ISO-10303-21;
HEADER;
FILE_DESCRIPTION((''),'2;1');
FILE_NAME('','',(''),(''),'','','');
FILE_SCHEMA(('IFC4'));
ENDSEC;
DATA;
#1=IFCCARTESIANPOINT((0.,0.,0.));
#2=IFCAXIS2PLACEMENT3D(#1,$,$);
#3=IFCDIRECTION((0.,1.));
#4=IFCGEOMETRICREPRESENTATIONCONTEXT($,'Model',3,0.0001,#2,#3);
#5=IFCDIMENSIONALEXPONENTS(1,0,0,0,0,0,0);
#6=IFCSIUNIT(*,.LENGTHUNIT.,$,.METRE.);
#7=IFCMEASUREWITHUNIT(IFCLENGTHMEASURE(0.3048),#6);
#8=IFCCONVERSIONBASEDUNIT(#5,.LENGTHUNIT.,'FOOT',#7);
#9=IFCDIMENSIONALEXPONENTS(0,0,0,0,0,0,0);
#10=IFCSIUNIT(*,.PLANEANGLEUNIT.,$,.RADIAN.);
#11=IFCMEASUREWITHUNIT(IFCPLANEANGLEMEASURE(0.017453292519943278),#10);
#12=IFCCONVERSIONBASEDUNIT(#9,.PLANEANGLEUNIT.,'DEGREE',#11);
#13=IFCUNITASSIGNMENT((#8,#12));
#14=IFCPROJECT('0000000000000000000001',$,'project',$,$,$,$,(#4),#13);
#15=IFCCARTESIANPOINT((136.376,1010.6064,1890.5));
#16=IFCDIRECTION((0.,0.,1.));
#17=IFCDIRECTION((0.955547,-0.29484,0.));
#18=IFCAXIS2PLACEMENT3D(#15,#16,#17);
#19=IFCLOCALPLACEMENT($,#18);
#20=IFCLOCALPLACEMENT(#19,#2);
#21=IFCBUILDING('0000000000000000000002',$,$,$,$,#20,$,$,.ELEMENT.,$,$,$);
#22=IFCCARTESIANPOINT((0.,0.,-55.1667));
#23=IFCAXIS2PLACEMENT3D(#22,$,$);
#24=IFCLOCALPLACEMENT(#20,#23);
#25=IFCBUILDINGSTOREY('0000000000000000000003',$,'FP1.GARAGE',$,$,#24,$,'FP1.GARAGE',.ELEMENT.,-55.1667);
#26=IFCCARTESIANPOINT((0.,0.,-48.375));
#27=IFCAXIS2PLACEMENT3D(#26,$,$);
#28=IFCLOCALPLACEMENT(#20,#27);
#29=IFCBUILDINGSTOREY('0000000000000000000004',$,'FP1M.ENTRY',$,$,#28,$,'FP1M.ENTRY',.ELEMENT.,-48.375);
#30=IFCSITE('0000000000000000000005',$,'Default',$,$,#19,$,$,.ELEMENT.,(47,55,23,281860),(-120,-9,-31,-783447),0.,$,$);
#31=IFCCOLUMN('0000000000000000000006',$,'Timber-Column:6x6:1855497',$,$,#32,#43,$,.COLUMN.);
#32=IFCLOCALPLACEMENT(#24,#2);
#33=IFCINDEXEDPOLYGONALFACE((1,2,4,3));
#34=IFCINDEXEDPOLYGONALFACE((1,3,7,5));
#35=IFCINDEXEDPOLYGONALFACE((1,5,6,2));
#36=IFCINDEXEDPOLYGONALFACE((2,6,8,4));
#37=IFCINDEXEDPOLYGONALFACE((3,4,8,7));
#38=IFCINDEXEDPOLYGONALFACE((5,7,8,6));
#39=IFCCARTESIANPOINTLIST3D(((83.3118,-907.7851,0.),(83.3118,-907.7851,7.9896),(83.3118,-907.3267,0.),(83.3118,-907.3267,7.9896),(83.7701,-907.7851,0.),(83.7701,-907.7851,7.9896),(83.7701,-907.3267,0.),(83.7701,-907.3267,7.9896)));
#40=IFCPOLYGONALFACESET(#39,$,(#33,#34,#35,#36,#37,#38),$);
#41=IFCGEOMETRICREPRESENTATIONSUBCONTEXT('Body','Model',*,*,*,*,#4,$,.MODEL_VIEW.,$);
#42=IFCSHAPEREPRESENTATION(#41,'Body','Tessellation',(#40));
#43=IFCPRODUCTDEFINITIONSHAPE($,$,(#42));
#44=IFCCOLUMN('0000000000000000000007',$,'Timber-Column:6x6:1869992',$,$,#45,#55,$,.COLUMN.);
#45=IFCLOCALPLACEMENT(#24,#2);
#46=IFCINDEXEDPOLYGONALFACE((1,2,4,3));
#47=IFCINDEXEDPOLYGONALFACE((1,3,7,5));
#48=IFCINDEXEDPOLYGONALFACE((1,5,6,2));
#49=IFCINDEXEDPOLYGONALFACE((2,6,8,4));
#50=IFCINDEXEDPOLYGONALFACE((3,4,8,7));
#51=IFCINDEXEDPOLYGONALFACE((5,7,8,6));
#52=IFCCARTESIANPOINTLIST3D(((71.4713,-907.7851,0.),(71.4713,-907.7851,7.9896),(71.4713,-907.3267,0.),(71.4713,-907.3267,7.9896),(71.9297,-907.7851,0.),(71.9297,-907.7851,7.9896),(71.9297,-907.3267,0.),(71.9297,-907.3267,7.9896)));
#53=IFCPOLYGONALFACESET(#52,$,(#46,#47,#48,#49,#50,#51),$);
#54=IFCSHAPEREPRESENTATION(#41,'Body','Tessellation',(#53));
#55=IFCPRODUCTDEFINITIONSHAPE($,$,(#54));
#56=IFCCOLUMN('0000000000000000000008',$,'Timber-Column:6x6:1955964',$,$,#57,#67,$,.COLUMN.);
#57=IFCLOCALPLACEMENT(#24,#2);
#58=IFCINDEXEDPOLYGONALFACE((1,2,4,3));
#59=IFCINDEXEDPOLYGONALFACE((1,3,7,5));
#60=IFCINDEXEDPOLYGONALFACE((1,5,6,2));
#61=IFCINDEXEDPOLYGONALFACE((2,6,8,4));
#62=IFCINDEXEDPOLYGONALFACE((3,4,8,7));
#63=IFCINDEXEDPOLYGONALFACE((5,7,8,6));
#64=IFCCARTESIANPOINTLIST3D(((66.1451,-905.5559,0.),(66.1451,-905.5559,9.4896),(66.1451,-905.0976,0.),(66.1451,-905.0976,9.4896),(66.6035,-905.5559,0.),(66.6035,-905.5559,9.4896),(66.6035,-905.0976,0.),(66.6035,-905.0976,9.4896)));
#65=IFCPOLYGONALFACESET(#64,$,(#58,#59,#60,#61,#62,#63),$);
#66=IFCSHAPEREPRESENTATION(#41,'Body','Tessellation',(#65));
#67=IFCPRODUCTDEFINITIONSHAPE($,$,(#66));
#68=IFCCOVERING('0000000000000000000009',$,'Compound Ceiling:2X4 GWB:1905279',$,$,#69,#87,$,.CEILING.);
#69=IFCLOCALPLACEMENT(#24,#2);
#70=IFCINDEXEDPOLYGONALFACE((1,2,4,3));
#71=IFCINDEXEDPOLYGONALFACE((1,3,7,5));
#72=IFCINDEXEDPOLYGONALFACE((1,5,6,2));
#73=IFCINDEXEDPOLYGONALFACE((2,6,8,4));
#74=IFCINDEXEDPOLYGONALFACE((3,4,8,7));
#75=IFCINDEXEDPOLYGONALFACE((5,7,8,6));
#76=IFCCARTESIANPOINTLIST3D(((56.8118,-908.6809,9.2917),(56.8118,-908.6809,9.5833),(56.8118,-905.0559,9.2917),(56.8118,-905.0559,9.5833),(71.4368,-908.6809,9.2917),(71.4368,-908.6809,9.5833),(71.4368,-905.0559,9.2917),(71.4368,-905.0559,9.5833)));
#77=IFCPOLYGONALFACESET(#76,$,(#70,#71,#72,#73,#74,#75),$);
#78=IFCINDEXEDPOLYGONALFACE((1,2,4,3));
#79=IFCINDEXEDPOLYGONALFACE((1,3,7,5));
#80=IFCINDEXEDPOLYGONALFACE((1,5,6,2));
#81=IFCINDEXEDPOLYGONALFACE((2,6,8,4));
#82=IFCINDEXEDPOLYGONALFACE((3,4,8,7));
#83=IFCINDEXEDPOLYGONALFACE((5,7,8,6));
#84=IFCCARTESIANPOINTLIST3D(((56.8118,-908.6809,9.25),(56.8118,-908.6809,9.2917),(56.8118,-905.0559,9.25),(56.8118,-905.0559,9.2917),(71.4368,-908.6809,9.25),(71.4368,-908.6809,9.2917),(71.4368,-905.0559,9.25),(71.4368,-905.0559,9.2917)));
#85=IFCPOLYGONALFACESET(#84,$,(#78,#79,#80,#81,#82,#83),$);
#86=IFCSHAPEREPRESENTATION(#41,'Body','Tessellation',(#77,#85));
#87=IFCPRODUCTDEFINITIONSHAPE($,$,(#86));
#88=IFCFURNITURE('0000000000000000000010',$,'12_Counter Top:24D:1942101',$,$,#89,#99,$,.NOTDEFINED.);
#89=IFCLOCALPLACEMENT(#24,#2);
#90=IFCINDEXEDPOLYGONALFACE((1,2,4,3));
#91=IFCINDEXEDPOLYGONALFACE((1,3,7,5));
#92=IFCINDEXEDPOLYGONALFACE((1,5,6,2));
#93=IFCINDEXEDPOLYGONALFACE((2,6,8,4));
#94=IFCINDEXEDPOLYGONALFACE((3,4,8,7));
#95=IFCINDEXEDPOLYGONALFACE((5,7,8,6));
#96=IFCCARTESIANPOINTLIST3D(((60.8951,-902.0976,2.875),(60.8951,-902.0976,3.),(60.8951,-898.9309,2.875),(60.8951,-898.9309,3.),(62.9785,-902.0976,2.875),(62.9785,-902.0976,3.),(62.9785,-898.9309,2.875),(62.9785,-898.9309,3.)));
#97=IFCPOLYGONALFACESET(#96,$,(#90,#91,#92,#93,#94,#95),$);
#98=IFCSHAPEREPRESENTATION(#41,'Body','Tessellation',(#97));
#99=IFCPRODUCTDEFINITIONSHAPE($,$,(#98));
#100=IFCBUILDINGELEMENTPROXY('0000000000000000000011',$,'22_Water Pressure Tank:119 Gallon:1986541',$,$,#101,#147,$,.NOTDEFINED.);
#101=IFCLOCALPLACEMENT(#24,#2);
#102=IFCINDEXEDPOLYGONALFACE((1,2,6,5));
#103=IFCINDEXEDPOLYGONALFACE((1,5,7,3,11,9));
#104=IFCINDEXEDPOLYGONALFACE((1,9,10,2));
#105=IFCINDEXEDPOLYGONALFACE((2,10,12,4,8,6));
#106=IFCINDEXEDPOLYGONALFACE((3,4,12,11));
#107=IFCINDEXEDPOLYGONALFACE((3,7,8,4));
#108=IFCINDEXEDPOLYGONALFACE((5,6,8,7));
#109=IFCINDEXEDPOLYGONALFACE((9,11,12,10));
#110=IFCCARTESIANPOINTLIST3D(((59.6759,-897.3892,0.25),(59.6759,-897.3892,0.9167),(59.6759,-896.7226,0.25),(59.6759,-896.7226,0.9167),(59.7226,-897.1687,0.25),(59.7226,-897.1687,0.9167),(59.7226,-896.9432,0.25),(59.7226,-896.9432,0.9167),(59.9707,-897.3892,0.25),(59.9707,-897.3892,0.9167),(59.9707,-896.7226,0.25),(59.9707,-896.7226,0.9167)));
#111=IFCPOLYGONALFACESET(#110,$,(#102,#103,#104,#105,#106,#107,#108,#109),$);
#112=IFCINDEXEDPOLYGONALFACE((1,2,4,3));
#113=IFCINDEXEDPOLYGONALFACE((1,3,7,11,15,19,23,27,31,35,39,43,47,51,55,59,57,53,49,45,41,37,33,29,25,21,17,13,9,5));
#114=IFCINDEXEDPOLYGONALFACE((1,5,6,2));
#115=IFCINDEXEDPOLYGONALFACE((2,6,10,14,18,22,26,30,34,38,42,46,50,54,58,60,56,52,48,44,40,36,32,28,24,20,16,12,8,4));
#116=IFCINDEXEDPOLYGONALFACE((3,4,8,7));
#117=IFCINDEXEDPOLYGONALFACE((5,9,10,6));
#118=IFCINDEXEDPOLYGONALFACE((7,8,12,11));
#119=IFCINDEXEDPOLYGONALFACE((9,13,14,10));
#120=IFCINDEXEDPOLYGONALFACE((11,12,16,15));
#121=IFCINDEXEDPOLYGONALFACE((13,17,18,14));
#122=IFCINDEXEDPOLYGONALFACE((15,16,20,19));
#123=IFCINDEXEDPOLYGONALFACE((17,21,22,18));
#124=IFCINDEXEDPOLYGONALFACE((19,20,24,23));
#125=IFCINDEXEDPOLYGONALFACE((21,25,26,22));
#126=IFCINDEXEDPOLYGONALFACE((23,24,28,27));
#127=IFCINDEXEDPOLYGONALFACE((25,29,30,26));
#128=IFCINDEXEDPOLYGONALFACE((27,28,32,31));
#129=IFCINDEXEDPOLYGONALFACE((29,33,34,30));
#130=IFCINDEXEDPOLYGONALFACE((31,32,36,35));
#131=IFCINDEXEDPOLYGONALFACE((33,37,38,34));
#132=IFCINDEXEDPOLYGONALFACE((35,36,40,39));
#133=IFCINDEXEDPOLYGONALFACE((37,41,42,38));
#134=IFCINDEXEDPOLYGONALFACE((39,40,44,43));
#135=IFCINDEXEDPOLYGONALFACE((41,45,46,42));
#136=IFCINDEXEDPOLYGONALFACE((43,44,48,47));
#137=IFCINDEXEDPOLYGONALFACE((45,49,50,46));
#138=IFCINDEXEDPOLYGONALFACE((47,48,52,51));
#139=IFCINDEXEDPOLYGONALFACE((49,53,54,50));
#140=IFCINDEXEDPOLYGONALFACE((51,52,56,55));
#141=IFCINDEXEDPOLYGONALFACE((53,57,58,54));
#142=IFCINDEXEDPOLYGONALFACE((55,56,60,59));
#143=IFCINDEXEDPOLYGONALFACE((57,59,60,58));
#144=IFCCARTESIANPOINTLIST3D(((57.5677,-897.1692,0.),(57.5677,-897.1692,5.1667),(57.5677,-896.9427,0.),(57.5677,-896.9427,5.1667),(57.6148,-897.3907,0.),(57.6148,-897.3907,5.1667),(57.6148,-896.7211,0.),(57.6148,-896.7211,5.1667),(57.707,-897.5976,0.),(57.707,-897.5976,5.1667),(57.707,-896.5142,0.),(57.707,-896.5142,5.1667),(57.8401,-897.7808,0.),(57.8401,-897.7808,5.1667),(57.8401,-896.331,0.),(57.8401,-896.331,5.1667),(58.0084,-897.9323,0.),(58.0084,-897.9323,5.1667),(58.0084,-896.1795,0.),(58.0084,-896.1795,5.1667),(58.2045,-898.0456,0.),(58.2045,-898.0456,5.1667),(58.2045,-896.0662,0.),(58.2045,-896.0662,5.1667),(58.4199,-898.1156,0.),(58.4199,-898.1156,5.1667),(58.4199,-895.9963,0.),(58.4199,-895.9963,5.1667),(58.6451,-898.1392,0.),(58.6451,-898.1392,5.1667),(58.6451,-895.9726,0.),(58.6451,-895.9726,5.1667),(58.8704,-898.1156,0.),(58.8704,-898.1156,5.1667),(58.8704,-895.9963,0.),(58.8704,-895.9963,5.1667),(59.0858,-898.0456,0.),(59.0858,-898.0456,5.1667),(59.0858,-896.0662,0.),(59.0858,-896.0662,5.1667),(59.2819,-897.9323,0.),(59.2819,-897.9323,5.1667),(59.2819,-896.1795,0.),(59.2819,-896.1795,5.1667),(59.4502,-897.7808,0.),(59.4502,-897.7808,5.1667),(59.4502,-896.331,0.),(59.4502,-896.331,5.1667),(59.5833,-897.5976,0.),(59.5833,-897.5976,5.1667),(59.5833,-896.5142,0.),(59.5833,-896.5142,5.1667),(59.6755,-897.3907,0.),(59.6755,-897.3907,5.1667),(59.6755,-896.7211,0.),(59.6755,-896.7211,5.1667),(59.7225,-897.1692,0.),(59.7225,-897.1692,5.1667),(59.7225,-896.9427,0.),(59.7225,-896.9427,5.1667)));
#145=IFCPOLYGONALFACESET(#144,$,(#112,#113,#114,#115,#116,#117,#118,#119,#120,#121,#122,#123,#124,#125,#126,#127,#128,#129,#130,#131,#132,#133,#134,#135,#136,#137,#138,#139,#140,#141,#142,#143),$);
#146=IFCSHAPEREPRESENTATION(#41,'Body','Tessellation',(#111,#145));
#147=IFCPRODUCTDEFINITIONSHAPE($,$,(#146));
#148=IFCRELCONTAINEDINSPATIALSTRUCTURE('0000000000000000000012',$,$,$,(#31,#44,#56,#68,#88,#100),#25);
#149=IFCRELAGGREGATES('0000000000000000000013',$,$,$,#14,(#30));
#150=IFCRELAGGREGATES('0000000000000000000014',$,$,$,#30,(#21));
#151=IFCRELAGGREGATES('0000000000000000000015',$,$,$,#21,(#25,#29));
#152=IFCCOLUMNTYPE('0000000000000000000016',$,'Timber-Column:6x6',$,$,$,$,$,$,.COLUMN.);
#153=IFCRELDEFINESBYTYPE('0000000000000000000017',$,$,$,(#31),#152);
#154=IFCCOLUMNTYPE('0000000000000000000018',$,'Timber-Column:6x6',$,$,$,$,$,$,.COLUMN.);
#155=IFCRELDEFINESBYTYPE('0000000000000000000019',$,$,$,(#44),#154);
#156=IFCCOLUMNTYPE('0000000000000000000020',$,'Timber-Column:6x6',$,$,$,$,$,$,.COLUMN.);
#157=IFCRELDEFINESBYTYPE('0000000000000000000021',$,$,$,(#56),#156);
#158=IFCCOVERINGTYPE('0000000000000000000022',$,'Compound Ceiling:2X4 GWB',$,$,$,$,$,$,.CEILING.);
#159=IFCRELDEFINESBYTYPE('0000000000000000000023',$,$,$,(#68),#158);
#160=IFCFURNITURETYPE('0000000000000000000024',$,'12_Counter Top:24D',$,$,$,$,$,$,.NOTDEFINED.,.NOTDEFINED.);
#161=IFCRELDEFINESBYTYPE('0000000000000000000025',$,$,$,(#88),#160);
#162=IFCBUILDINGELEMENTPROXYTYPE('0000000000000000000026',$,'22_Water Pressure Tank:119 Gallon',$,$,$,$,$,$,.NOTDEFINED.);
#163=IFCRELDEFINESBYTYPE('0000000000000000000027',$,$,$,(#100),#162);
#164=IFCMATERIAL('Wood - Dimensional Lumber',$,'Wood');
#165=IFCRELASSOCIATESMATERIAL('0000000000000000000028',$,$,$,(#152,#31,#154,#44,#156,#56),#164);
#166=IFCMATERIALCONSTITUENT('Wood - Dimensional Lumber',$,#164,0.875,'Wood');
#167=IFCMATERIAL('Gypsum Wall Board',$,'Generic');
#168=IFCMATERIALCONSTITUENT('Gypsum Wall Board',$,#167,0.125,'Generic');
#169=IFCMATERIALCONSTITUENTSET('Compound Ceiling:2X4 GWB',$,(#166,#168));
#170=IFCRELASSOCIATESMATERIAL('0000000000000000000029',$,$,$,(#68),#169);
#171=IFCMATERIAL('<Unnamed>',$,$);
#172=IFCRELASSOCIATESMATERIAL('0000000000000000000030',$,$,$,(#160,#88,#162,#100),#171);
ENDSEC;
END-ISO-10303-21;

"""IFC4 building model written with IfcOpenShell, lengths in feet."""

from ifc_helpers import new_model, entity, si_unit, converted_unit, direction, frame, origin, place, context, subcontext, project, spatial, line, arc, indexed_curve, outline, extrude, source, transform, mapped, material, constituent, constituent_set, type_object, type_shapes, element, save


model = new_model("IFC4")

# Units and contexts
model_context = context("Model", 3, precision=0.0001, world=origin(), true_north=direction((0.0, 1.0)))
body_context = subcontext(model_context, "Body", "Model", "MODEL_VIEW")
ifc_project = project(units=[converted_unit("LENGTHUNIT", "FOOT", entity("IfcLengthMeasure", 0.3048), si_unit("LENGTHUNIT", "METRE"), dimensions=[1, 0, 0, 0, 0, 0, 0]), converted_unit("PLANEANGLEUNIT", "DEGREE", entity("IfcPlaneAngleMeasure", 0.017453292519943278), si_unit("PLANEANGLEUNIT", "RADIAN"), dimensions=[0, 0, 0, 0, 0, 0, 0])], contexts=[model_context])

# Site, building, storey
site_placement = place(None, frame((136.376, 1010.6064, 1890.5), z_axis=(0.0, 0.0, 1.0), x_axis=(0.955547, -0.29484, 0.0)))
site = spatial("IfcSite", under=ifc_project, at=site_placement, Name="Default", CompositionType="ELEMENT", RefLatitude=(47, 55, 23, 281860), RefLongitude=(-120, -9, -31, -783447), RefElevation=0.0)
building_placement = place(site_placement, origin())
building = spatial("IfcBuilding", under=site, at=building_placement, CompositionType="ELEMENT")
storey_1_placement = place(building_placement, frame((0.0, 0.0, -55.1667)))
storey_1 = spatial("IfcBuildingStorey", under=building, at=storey_1_placement, Name="FP1.GARAGE", LongName="FP1.GARAGE", CompositionType="ELEMENT", Elevation=-55.1667)

# Columns
ifc_material_1 = material(Name="Wood - Dimensional Lumber", Category="Wood")
column_type_1 = type_object("IfcColumnType", Name="Timber-Column:6x6", PredefinedType="COLUMN", material=ifc_material_1)
shared_shape_1 = source(origin(), body_context, "Body", "SweptSolid", [
    extrude(outline(indexed_curve([(-0.2292, -0.2292), (0.2292, -0.2292), (0.2292, 0.2292), (-0.2292, 0.2292), (-0.2292, -0.2292)], self_intersect=False)), frame((83.541, -907.5559, -55.1667), z_axis=(0.0, 0.0, 1.0), x_axis=(-1.0, 0.0, 0.0)), (0.0, 0.0, 1.0), 7.9896),
])
type_shapes(column_type_1, [shared_shape_1])
column_1_placement = place(storey_1_placement, frame((0.0, 0.0, 55.1667)))
element("IfcColumn", 1, at=column_1_placement, inside=storey_1, type_object=column_type_1, material=ifc_material_1, Name="Timber-Column:6x6:1855497", PredefinedType="COLUMN", context=body_context, shape_type="MappedRepresentation", body=[
    mapped(shared_shape_1, transform((0.0, 0.0, 0.0), scale=1.0)),
])
column_type_2 = type_object("IfcColumnType", Name="Timber-Column:6x6", PredefinedType="COLUMN", material=ifc_material_1)
shared_shape_2 = source(origin(), body_context, "Body", "SweptSolid", [
    extrude(outline(indexed_curve([(-0.2292, -0.2292), (0.2292, -0.2292), (0.2292, 0.2292), (-0.2292, 0.2292), (-0.2292, -0.2292)], self_intersect=False)), frame((71.7005, -907.5559, -55.1667), z_axis=(0.0, 0.0, 1.0), x_axis=(-1.0, 0.0, 0.0)), (0.0, 0.0, 1.0), 7.9896),
])
type_shapes(column_type_2, [shared_shape_2])
column_2_placement = place(storey_1_placement, frame((0.0, 0.0, 55.1667)))
element("IfcColumn", 2, at=column_2_placement, inside=storey_1, type_object=column_type_2, material=ifc_material_1, Name="Timber-Column:6x6:1869992", PredefinedType="COLUMN", context=body_context, shape_type="MappedRepresentation", body=[
    mapped(shared_shape_2, transform((0.0, 0.0, 0.0), scale=1.0)),
])
column_type_3 = type_object("IfcColumnType", Name="Timber-Column:6x6", PredefinedType="COLUMN", material=ifc_material_1)
shared_shape_3 = source(origin(), body_context, "Body", "SweptSolid", [
    extrude(outline(indexed_curve([(-0.2292, -0.2292), (0.2292, -0.2292), (0.2292, 0.2292), (-0.2292, 0.2292), (-0.2292, -0.2292)], self_intersect=False)), frame((66.3743, -905.3267, -55.1667), z_axis=(0.0, 0.0, 1.0), x_axis=(-1.0, 0.0, 0.0)), (0.0, 0.0, 1.0), 9.4896),
])
type_shapes(column_type_3, [shared_shape_3])
column_3_placement = place(storey_1_placement, frame((0.0, 0.0, 55.1667)))
element("IfcColumn", 3, at=column_3_placement, inside=storey_1, type_object=column_type_3, material=ifc_material_1, Name="Timber-Column:6x6:1955964", PredefinedType="COLUMN", context=body_context, shape_type="MappedRepresentation", body=[
    mapped(shared_shape_3, transform((0.0, 0.0, 0.0), scale=1.0)),
])

# Shared definitions
ifc_material_2 = material(Name="<Unnamed>")

# Shared definitions
ifc_material_3 = material(Name="Gypsum Wall Board", Category="Generic")

# Shared definitions
storey_2_placement = place(building_placement, frame((0.0, 0.0, -48.375)))
storey_2 = spatial("IfcBuildingStorey", under=building, at=storey_2_placement, Name="FP1M.ENTRY", LongName="FP1M.ENTRY", CompositionType="ELEMENT", Elevation=-48.375)

# Covering
ifc_constituent_1 = constituent(ifc_material_1, Name="Wood - Dimensional Lumber", Category="Wood", fraction=0.875)
ifc_constituent_2 = constituent(ifc_material_3, Name="Gypsum Wall Board", Category="Generic", fraction=0.125)
ifc_constituent_set_1 = constituent_set(constituents=[ifc_constituent_1, ifc_constituent_2], Name="Compound Ceiling:2X4 GWB")
covering_type = type_object("IfcCoveringType", Name="Compound Ceiling:2X4 GWB", PredefinedType="CEILING")
covering_placement = place(storey_1_placement, origin())
element("IfcCovering", 4, at=covering_placement, inside=storey_1, type_object=covering_type, material=ifc_constituent_set_1, Name="Compound Ceiling:2X4 GWB:1905279", PredefinedType="CEILING", context=body_context, shape_type="SweptSolid", body=[
    extrude(outline(indexed_curve([(-7.3125, -1.8125), (7.3125, -1.8125), (7.3125, 1.8125), (-7.3125, 1.8125), (-7.3125, -1.8125)], self_intersect=False)), frame((64.1243, -906.8684, 9.2917)), (0.0, 0.0, 1.0), 0.2917),
    extrude(outline(indexed_curve([(-7.3125, -1.8125), (7.3125, -1.8125), (7.3125, 1.8125), (-7.3125, 1.8125), (-7.3125, -1.8125)], self_intersect=False)), frame((64.1243, -906.8684, 9.25)), (0.0, 0.0, 1.0), 0.0417),
])

# Furniture
furniture_type = type_object("IfcFurnitureType", Name="12_Counter Top:24D", AssemblyPlace="NOTDEFINED", PredefinedType="NOTDEFINED", material=ifc_material_2)
shared_shape_4 = source(origin(), body_context, "Body", "SweptSolid", [
    extrude(outline(indexed_curve([(-1.5833, -1.0417), (1.5833, -1.0417), (1.5833, 1.0417), (-1.5833, 1.0417), (-1.5833, -1.0417)], self_intersect=False)), frame((-2.3552, -1.0417, 2.875), z_axis=(0.0, 0.0, 1.0), x_axis=(-1.0, 0.0, 0.0)), (0.0, 0.0, 1.0), 0.125),
])
type_shapes(furniture_type, [shared_shape_4])
furniture_placement = place(storey_1_placement, frame((60.8951, -898.1591, 0.0), z_axis=(0.0, 0.0, 1.0), x_axis=(0.0, 1.0, 0.0)))
element("IfcFurniture", 5, at=furniture_placement, inside=storey_1, type_object=furniture_type, material=ifc_material_2, Name="12_Counter Top:24D:1942101", PredefinedType="NOTDEFINED", context=body_context, shape_type="MappedRepresentation", body=[
    mapped(shared_shape_4, transform((0.0, 0.0, 0.0), scale=1.0)),
])

# Building element proxy
building_element_proxy_type = type_object("IfcBuildingElementProxyType", Name="22_Water Pressure Tank:119 Gallon", PredefinedType="NOTDEFINED", material=ifc_material_2)
shared_shape_5 = source(origin(), body_context, "Body", "SweptSolid", [
    extrude(outline(indexed_curve([(-0.3333, -0.1474), (0.3333, -0.1474), (0.3333, 0.1474), (0.0, 0.0948), (-0.3333, 0.1474)], segments=[line(1, 2, 3), arc(3, 4, 5), line(5, 1)], self_intersect=False)), frame((0.0, -1.1781, 0.25)), (0.0, 0.0, 1.0), 0.6667),
    extrude(outline(indexed_curve([(-1.0833, 0.0), (0.0, -1.0833), (1.0833, 0.0), (0.0, 1.0833)], segments=[arc(1, 2, 3), arc(3, 4, 1)], self_intersect=False)), origin(), (0.0, 0.0, 1.0), 5.1667),
])
type_shapes(building_element_proxy_type, [shared_shape_5])
proxy_placement = place(storey_1_placement, frame((58.6451, -897.0559, 0.0), z_axis=(0.0, 0.0, 1.0), x_axis=(0.0, 1.0, 0.0)))
element("IfcBuildingElementProxy", 6, at=proxy_placement, inside=storey_1, type_object=building_element_proxy_type, material=ifc_material_2, Name="22_Water Pressure Tank:119 Gallon:1986541", PredefinedType="NOTDEFINED", context=body_context, shape_type="MappedRepresentation", body=[
    mapped(shared_shape_5, transform((0.0, 0.0, 0.0), scale=1.0)),
])

save(model, "model.ifc")
